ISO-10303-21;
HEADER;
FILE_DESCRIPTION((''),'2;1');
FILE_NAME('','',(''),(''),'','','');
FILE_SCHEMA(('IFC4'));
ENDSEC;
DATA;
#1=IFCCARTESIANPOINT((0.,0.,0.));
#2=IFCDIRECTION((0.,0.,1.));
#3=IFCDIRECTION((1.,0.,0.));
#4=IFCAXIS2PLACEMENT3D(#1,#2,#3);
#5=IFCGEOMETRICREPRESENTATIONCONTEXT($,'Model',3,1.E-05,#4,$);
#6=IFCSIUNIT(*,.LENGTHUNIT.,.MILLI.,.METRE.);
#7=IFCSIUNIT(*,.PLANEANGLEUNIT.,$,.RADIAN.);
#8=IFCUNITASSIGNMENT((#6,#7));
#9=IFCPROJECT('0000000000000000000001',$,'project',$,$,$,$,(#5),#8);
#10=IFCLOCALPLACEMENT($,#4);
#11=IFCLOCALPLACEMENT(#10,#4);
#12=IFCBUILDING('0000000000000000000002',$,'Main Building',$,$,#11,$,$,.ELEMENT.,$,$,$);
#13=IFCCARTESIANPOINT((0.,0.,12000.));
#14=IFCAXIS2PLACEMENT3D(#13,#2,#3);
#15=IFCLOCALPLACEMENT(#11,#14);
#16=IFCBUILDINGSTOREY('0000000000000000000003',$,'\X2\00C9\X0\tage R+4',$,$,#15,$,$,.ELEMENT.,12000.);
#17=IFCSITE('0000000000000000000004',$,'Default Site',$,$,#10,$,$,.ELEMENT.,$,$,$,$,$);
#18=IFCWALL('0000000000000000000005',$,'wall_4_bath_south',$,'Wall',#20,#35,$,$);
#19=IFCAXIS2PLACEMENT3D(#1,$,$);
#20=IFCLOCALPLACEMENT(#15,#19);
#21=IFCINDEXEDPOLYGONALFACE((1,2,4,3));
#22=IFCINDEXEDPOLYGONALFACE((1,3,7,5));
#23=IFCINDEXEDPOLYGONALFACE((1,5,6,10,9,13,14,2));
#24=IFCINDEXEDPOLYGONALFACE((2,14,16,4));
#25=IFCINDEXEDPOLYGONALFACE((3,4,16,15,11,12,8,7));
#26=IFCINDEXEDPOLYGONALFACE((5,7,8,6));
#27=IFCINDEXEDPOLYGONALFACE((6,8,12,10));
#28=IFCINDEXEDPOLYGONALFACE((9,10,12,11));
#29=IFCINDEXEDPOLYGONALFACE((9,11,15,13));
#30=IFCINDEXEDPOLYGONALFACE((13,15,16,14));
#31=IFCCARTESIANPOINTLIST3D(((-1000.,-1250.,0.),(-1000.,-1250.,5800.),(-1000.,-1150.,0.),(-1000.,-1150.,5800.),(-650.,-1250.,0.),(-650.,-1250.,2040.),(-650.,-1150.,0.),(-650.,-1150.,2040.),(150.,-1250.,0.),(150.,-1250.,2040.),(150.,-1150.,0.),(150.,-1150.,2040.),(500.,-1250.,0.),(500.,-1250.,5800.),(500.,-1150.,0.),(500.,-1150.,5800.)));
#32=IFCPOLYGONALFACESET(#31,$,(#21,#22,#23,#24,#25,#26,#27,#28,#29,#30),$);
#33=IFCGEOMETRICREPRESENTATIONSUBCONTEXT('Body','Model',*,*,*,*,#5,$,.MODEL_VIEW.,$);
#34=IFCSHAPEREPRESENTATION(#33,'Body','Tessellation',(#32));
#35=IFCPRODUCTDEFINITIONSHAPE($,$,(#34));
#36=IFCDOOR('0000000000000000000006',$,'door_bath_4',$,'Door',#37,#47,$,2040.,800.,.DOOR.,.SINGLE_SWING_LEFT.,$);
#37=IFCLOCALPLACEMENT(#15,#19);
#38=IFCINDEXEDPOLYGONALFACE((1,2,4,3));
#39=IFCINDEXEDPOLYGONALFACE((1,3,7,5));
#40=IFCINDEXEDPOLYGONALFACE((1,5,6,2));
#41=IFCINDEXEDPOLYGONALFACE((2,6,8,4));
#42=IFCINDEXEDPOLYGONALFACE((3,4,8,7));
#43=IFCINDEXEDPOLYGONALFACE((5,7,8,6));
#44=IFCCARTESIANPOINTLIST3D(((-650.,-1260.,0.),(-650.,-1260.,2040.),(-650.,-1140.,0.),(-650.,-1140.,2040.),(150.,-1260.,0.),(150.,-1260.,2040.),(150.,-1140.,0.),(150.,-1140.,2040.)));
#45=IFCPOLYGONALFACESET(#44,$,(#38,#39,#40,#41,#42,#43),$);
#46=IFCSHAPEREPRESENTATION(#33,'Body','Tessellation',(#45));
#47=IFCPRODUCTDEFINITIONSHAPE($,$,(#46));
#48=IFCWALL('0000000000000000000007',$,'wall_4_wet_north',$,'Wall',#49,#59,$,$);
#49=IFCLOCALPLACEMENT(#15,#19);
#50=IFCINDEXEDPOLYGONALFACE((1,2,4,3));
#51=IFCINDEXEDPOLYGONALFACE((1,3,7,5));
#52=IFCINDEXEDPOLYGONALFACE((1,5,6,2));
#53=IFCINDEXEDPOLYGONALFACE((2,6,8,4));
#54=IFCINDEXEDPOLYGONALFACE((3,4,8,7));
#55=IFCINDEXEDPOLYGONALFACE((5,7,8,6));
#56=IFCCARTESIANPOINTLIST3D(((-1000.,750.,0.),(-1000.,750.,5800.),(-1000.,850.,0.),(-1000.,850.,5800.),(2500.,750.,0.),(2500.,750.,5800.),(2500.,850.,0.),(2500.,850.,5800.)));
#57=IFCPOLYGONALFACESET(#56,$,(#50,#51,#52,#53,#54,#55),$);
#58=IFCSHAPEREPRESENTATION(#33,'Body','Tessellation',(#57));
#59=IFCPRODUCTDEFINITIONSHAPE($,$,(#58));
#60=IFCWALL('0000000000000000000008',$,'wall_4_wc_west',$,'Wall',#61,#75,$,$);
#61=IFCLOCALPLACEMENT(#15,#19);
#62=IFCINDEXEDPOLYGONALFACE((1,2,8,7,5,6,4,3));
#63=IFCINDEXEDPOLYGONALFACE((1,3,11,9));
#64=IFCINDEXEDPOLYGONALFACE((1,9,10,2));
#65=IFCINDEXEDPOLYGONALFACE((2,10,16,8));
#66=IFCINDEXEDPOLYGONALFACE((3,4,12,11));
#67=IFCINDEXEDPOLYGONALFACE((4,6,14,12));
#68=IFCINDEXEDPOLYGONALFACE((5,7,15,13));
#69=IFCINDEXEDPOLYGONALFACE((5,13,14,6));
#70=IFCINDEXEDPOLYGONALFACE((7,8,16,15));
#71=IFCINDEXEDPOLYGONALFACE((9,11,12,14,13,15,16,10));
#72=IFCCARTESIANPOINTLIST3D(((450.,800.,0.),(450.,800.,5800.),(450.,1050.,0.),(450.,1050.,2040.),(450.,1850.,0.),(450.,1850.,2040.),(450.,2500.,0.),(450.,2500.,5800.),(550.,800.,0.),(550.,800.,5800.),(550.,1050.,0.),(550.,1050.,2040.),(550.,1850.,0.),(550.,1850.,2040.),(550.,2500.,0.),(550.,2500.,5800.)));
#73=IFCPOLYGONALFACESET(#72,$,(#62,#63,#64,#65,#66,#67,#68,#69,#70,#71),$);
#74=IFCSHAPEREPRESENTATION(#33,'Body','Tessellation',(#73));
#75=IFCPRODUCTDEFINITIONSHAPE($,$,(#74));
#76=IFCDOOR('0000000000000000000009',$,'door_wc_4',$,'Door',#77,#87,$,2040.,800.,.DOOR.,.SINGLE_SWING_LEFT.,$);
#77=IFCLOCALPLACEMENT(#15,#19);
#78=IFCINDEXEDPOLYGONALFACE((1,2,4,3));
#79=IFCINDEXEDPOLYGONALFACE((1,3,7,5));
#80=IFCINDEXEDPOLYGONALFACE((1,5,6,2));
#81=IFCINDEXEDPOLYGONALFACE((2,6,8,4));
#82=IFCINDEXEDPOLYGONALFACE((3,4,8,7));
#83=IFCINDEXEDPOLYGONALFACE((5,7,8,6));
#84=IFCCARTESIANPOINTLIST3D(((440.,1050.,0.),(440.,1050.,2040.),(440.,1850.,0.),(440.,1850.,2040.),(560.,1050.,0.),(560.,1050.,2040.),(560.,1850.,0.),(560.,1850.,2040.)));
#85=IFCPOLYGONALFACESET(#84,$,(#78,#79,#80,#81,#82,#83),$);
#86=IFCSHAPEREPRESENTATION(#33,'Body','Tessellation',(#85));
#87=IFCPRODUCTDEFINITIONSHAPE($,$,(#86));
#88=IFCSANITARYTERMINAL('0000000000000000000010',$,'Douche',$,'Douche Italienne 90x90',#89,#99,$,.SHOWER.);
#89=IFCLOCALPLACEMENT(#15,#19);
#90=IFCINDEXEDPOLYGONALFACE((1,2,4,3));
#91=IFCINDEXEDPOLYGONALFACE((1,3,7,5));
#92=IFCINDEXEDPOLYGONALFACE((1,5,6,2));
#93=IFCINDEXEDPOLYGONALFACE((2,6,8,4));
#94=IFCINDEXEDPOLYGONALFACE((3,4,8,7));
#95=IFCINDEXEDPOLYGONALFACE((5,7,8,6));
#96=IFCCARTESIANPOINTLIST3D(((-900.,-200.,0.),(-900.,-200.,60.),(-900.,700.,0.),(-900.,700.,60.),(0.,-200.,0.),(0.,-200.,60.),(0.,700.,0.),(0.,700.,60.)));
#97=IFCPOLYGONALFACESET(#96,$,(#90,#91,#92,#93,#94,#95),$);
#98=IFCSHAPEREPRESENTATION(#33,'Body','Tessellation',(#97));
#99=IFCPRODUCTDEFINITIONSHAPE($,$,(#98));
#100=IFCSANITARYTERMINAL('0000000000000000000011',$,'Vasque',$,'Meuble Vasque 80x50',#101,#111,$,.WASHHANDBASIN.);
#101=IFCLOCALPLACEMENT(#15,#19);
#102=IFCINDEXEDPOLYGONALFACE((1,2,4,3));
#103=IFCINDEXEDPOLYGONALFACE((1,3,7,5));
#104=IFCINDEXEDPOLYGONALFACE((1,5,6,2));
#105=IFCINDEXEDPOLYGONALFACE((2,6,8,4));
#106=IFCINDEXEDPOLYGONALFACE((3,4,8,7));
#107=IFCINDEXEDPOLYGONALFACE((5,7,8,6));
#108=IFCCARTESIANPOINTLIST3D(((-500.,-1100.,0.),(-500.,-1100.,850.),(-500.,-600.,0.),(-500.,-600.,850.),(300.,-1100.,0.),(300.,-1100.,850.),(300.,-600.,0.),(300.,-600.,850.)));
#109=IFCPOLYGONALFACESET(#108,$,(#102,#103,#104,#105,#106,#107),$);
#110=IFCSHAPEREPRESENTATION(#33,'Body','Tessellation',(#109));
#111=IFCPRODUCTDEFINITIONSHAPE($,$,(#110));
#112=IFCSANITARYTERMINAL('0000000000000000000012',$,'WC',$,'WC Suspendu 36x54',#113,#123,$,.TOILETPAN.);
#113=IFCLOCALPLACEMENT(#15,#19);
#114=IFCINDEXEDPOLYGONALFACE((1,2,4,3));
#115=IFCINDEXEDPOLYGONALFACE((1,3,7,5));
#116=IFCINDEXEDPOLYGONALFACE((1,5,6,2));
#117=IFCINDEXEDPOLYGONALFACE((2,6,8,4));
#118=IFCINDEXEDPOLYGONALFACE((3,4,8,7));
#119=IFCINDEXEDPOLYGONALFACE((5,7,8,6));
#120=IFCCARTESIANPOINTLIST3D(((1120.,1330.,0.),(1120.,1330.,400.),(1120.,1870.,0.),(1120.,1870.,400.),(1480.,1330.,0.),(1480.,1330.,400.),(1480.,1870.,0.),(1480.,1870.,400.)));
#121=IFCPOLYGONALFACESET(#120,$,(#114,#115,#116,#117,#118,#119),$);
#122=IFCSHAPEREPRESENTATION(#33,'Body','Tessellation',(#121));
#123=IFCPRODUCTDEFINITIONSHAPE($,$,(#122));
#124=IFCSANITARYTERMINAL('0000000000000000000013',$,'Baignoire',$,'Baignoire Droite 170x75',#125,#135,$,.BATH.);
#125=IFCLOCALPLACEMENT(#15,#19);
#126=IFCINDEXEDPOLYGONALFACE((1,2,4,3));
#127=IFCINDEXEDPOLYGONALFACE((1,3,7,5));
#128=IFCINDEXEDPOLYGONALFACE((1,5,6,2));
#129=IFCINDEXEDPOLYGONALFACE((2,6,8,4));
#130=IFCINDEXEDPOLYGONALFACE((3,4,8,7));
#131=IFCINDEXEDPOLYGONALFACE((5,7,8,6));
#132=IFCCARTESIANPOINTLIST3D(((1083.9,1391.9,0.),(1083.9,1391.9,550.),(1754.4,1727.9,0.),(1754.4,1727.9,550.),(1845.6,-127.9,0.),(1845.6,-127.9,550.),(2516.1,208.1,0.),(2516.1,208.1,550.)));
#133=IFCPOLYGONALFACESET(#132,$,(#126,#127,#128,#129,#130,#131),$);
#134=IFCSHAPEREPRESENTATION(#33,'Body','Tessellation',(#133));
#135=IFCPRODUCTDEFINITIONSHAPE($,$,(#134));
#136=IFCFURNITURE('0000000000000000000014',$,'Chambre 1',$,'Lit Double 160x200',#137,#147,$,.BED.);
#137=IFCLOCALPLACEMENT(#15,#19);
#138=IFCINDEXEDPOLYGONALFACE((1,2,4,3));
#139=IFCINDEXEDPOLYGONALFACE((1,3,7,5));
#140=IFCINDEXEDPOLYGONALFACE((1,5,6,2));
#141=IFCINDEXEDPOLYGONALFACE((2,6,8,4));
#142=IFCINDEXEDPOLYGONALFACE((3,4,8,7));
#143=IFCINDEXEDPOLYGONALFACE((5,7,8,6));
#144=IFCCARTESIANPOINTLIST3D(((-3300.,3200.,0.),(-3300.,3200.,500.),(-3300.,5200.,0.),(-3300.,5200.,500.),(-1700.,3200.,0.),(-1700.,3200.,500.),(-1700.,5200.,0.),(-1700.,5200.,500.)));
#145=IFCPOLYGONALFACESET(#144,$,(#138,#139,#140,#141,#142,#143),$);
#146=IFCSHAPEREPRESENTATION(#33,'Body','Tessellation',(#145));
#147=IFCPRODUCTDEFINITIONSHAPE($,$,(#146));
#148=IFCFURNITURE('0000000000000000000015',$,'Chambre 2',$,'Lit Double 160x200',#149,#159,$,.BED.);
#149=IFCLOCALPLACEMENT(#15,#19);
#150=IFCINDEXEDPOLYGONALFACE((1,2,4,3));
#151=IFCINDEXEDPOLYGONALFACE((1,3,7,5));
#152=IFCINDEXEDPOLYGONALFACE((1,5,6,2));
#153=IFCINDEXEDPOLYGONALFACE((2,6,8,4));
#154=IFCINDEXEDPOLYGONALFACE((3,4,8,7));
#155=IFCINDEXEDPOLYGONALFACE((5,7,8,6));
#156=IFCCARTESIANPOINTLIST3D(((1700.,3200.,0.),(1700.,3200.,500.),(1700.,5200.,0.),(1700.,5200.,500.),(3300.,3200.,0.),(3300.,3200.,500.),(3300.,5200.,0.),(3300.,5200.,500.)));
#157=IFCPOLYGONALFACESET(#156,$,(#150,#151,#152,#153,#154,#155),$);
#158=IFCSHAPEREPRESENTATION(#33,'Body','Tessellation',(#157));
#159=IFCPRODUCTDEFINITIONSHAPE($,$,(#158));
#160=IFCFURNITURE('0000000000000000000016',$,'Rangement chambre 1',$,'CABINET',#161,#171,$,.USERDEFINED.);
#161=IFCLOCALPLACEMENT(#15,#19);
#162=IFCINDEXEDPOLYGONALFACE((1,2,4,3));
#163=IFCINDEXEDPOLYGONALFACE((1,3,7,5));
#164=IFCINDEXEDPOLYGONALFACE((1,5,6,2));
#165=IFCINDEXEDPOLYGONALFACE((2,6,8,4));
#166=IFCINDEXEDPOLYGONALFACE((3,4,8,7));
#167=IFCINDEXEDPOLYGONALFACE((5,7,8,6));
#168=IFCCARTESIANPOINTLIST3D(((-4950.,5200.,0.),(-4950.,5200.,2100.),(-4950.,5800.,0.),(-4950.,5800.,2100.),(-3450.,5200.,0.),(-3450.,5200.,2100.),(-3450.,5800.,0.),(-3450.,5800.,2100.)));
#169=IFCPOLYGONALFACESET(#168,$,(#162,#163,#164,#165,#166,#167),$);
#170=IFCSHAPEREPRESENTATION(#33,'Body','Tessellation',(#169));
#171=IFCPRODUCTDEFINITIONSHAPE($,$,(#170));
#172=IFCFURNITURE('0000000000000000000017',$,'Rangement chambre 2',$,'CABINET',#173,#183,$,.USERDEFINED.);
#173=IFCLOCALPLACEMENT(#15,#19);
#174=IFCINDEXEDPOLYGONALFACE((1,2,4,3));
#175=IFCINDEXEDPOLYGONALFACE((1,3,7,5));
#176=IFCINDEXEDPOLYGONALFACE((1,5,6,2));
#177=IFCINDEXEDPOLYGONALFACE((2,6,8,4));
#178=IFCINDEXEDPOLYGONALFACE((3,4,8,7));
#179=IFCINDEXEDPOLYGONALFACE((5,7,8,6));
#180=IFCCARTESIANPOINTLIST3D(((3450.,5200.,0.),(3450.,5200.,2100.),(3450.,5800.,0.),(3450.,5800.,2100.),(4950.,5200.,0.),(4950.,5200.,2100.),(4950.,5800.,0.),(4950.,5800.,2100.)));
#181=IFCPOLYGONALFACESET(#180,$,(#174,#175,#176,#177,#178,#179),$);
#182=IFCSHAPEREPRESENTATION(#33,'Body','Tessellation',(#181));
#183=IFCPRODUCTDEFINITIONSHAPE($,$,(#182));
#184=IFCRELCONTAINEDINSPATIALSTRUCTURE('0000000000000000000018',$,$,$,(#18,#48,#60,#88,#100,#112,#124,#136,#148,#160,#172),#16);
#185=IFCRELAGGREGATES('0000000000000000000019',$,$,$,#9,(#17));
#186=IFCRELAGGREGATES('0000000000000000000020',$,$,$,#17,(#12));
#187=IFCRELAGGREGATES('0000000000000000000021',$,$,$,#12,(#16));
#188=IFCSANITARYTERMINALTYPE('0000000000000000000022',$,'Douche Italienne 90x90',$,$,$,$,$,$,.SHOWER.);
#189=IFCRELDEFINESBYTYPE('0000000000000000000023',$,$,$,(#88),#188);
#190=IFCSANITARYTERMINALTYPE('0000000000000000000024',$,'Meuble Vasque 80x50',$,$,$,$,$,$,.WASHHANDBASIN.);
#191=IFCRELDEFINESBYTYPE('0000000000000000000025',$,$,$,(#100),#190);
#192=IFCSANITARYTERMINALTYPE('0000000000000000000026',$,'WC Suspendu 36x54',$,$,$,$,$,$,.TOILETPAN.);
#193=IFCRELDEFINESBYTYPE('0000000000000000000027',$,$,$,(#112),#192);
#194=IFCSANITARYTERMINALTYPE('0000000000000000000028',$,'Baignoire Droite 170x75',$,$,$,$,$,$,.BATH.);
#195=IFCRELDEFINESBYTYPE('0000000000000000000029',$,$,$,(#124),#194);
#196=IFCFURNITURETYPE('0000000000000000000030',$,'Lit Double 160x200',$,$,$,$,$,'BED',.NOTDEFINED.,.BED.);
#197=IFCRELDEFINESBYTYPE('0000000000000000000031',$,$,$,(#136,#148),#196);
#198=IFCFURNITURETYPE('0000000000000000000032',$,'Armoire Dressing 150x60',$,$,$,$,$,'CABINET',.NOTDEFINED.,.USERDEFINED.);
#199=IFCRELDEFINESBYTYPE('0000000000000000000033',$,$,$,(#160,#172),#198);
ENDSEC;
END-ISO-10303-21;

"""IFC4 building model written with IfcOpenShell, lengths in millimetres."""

from ifc_helpers import new_model, si_unit, frame, origin_with_axes, place, context, subcontext, project, spatial, polyline, outline, extrude, type_object, element, fill, save


model = new_model("IFC4")

# Units and contexts
model_context = context("Model", 3, precision=1e-05, world=origin_with_axes())
body_context = subcontext(model_context, "Body", "Model", "MODEL_VIEW")
ifc_project = project(units=[si_unit("LENGTHUNIT", "METRE", prefix="MILLI"), si_unit("PLANEANGLEUNIT", "RADIAN")], contexts=[model_context])

# Site, building, storey
site_placement = place(None, origin_with_axes())
site = spatial("IfcSite", under=ifc_project, at=site_placement, Name="Default Site", CompositionType="ELEMENT")
building_placement = place(site_placement, origin_with_axes())
building = spatial("IfcBuilding", under=site, at=building_placement, Name="Main Building", CompositionType="ELEMENT")
storey_placement = place(building_placement, frame((0.0, 0.0, 12000.0), z_axis=(0.0, 0.0, 1.0), x_axis=(1.0, 0.0, 0.0)))
storey = spatial("IfcBuildingStorey", under=building, at=storey_placement, Name="Étage R+4", CompositionType="ELEMENT", Elevation=12000.0)

# Wall, opening, door
wall_1_placement = place(storey_placement, frame((-1000.0, -1200.0, 0.0), z_axis=(0.0, 0.0, 1.0), x_axis=(1.0, 0.0, 0.0)))
wall_1 = element("IfcWall", 1, at=wall_1_placement, inside=storey, Name="wall_4_bath_south", ObjectType="Wall", context=body_context, shape_type="SweptSolid", body=[
    extrude(outline(polyline([(0.0, -50.0), (1500.0, -50.0), (1500.0, 50.0), (0.0, 50.0), (0.0, -50.0)])), origin_with_axes(), (0.0, 0.0, 1.0), 5800.0),
])
placement_1 = place(wall_1_placement, frame((350.0, 0.0, 0.0), z_axis=(0.0, 0.0, 1.0), x_axis=(1.0, 0.0, 0.0)))
opening_1 = element("IfcOpeningElement", 2, at=placement_1, cuts=wall_1, PredefinedType="OPENING", context=body_context, shape_type="SweptSolid", body=[
    extrude(outline(polyline([(0.0, -60.0), (800.0, -60.0), (800.0, 60.0), (0.0, 60.0), (0.0, -60.0)])), origin_with_axes(), (0.0, 0.0, 1.0), 2040.0),
])
door_1 = element("IfcDoor", 3, at=placement_1, Name="door_bath_4", ObjectType="Door", OperationType="SINGLE_SWING_LEFT", OverallHeight=2040.0, OverallWidth=800.0, PredefinedType="DOOR", context=body_context, shape_type="SweptSolid", body=[
    extrude(outline(polyline([(0.0, -60.0), (800.0, -60.0), (800.0, 60.0), (0.0, 60.0), (0.0, -60.0)])), origin_with_axes(), (0.0, 0.0, 1.0), 2040.0),
])
fill(opening_1, door_1)

# Wall
wall_2_placement = place(storey_placement, frame((-1000.0, 800.0, 0.0), z_axis=(0.0, 0.0, 1.0), x_axis=(1.0, 0.0, 0.0)))
element("IfcWall", 4, at=wall_2_placement, inside=storey, Name="wall_4_wet_north", ObjectType="Wall", context=body_context, shape_type="SweptSolid", body=[
    extrude(outline(polyline([(0.0, -50.0), (3500.0, -50.0), (3500.0, 50.0), (0.0, 50.0), (0.0, -50.0)])), origin_with_axes(), (0.0, 0.0, 1.0), 5800.0),
])

# Wall, opening, door
wall_3_placement = place(storey_placement, frame((500.0, 800.0, 0.0), z_axis=(0.0, 0.0, 1.0), x_axis=(0.0, 1.0, 0.0)))
wall_3 = element("IfcWall", 5, at=wall_3_placement, inside=storey, Name="wall_4_wc_west", ObjectType="Wall", context=body_context, shape_type="SweptSolid", body=[
    extrude(outline(polyline([(0.0, -50.0), (1700.0, -50.0), (1700.0, 50.0), (0.0, 50.0), (0.0, -50.0)])), origin_with_axes(), (0.0, 0.0, 1.0), 5800.0),
])
placement_2 = place(wall_3_placement, frame((250.0, 0.0, 0.0), z_axis=(0.0, 0.0, 1.0), x_axis=(1.0, 0.0, 0.0)))
opening_2 = element("IfcOpeningElement", 6, at=placement_2, cuts=wall_3, PredefinedType="OPENING", context=body_context, shape_type="SweptSolid", body=[
    extrude(outline(polyline([(0.0, -60.0), (800.0, -60.0), (800.0, 60.0), (0.0, 60.0), (0.0, -60.0)])), origin_with_axes(), (0.0, 0.0, 1.0), 2040.0),
])
door_2 = element("IfcDoor", 7, at=placement_2, Name="door_wc_4", ObjectType="Door", OperationType="SINGLE_SWING_LEFT", OverallHeight=2040.0, OverallWidth=800.0, PredefinedType="DOOR", context=body_context, shape_type="SweptSolid", body=[
    extrude(outline(polyline([(0.0, -60.0), (800.0, -60.0), (800.0, 60.0), (0.0, 60.0), (0.0, -60.0)])), origin_with_axes(), (0.0, 0.0, 1.0), 2040.0),
])
fill(opening_2, door_2)

# Sanitary terminals
sanitary_terminal_type_1 = type_object("IfcSanitaryTerminalType", Name="Douche Italienne 90x90", PredefinedType="SHOWER")
sanitary_terminal_1_placement = place(storey_placement, frame((-450.0, 250.0, 0.0), z_axis=(0.0, 0.0, 1.0), x_axis=(1.0, 0.0, 0.0)))
element("IfcSanitaryTerminal", 8, at=sanitary_terminal_1_placement, inside=storey, type_object=sanitary_terminal_type_1, Name="Douche", ObjectType="Douche Italienne 90x90", PredefinedType="SHOWER", context=body_context, shape_type="SweptSolid", body=[
    extrude(outline(polyline([(-450.0, -450.0), (450.0, -450.0), (450.0, 450.0), (-450.0, 450.0), (-450.0, -450.0)])), origin_with_axes(), (0.0, 0.0, 1.0), 60.0),
])
sanitary_terminal_type_2 = type_object("IfcSanitaryTerminalType", Name="Meuble Vasque 80x50", PredefinedType="WASHHANDBASIN")
sanitary_terminal_2_placement = place(storey_placement, frame((-100.0, -850.0, 0.0), z_axis=(0.0, 0.0, 1.0), x_axis=(1.0, 0.0, 0.0)))
element("IfcSanitaryTerminal", 9, at=sanitary_terminal_2_placement, inside=storey, type_object=sanitary_terminal_type_2, Name="Vasque", ObjectType="Meuble Vasque 80x50", PredefinedType="WASHHANDBASIN", context=body_context, shape_type="SweptSolid", body=[
    extrude(outline(polyline([(-400.0, -250.0), (400.0, -250.0), (400.0, 250.0), (-400.0, 250.0), (-400.0, -250.0)])), origin_with_axes(), (0.0, 0.0, 1.0), 850.0),
])
sanitary_terminal_type_3 = type_object("IfcSanitaryTerminalType", Name="WC Suspendu 36x54", PredefinedType="TOILETPAN")
sanitary_terminal_3_placement = place(storey_placement, frame((1300.0, 1600.0, 0.0), z_axis=(0.0, 0.0, 1.0), x_axis=(1.0, 0.0, 0.0)))
element("IfcSanitaryTerminal", 10, at=sanitary_terminal_3_placement, inside=storey, type_object=sanitary_terminal_type_3, Name="WC", ObjectType="WC Suspendu 36x54", PredefinedType="TOILETPAN", context=body_context, shape_type="SweptSolid", body=[
    extrude(outline(polyline([(-180.0, -270.0), (180.0, -270.0), (180.0, 270.0), (-180.0, 270.0), (-180.0, -270.0)])), origin_with_axes(), (0.0, 0.0, 1.0), 400.0),
])
sanitary_terminal_type_4 = type_object("IfcSanitaryTerminalType", Name="Baignoire Droite 170x75", PredefinedType="BATH")
sanitary_terminal_4_placement = place(storey_placement, frame((1800.0, 800.0, 0.0), z_axis=(0.0, 0.0, 1.0), x_axis=(-0.448074, 0.893997, 0.0)))
element("IfcSanitaryTerminal", 11, at=sanitary_terminal_4_placement, inside=storey, type_object=sanitary_terminal_type_4, Name="Baignoire", ObjectType="Baignoire Droite 170x75", PredefinedType="BATH", context=body_context, shape_type="SweptSolid", body=[
    extrude(outline(polyline([(-850.0, -375.0), (850.0, -375.0), (850.0, 375.0), (-850.0, 375.0), (-850.0, -375.0)])), origin_with_axes(), (0.0, 0.0, 1.0), 550.0),
])

# Furniture
furniture_type_1 = type_object("IfcFurnitureType", Name="Lit Double 160x200", ElementType="BED", AssemblyPlace="NOTDEFINED", PredefinedType="BED")
for number, where, z_axis, x_axis, name in (
    (12, (-2500.0, 4200.0, 0.0), (0.0, 0.0, 1.0), (1.0, 0.0, 0.0), "Chambre 1"),
    (13, (2500.0, 4200.0, 0.0), (0.0, 0.0, 1.0), (1.0, 0.0, 0.0), "Chambre 2"),
):
    element("IfcFurniture", number, at=place(storey_placement, frame(where, z_axis=z_axis, x_axis=x_axis)), inside=storey, type_object=furniture_type_1, Name=name, ObjectType="Lit Double 160x200", PredefinedType="BED", context=body_context, shape_type="SweptSolid", body=[
        extrude(outline(polyline([(-800.0, -1000.0), (800.0, -1000.0), (800.0, 1000.0), (-800.0, 1000.0), (-800.0, -1000.0)])), origin_with_axes(), (0.0, 0.0, 1.0), 500.0),
    ])
furniture_type_2 = type_object("IfcFurnitureType", Name="Armoire Dressing 150x60", ElementType="CABINET", AssemblyPlace="NOTDEFINED", PredefinedType="USERDEFINED")
for number, where, z_axis, x_axis, name in (
    (14, (-4200.0, 5500.0, 0.0), (0.0, 0.0, 1.0), (1.0, 0.0, 0.0), "Rangement chambre 1"),
    (15, (4200.0, 5500.0, 0.0), (0.0, 0.0, 1.0), (1.0, 0.0, 0.0), "Rangement chambre 2"),
):
    element("IfcFurniture", number, at=place(storey_placement, frame(where, z_axis=z_axis, x_axis=x_axis)), inside=storey, type_object=furniture_type_2, Name=name, ObjectType="CABINET", PredefinedType="USERDEFINED", context=body_context, shape_type="SweptSolid", body=[
        extrude(outline(polyline([(-750.0, -300.0), (750.0, -300.0), (750.0, 300.0), (-750.0, 300.0), (-750.0, -300.0)])), origin_with_axes(), (0.0, 0.0, 1.0), 2100.0),
    ])

save(model, "model.ifc")
